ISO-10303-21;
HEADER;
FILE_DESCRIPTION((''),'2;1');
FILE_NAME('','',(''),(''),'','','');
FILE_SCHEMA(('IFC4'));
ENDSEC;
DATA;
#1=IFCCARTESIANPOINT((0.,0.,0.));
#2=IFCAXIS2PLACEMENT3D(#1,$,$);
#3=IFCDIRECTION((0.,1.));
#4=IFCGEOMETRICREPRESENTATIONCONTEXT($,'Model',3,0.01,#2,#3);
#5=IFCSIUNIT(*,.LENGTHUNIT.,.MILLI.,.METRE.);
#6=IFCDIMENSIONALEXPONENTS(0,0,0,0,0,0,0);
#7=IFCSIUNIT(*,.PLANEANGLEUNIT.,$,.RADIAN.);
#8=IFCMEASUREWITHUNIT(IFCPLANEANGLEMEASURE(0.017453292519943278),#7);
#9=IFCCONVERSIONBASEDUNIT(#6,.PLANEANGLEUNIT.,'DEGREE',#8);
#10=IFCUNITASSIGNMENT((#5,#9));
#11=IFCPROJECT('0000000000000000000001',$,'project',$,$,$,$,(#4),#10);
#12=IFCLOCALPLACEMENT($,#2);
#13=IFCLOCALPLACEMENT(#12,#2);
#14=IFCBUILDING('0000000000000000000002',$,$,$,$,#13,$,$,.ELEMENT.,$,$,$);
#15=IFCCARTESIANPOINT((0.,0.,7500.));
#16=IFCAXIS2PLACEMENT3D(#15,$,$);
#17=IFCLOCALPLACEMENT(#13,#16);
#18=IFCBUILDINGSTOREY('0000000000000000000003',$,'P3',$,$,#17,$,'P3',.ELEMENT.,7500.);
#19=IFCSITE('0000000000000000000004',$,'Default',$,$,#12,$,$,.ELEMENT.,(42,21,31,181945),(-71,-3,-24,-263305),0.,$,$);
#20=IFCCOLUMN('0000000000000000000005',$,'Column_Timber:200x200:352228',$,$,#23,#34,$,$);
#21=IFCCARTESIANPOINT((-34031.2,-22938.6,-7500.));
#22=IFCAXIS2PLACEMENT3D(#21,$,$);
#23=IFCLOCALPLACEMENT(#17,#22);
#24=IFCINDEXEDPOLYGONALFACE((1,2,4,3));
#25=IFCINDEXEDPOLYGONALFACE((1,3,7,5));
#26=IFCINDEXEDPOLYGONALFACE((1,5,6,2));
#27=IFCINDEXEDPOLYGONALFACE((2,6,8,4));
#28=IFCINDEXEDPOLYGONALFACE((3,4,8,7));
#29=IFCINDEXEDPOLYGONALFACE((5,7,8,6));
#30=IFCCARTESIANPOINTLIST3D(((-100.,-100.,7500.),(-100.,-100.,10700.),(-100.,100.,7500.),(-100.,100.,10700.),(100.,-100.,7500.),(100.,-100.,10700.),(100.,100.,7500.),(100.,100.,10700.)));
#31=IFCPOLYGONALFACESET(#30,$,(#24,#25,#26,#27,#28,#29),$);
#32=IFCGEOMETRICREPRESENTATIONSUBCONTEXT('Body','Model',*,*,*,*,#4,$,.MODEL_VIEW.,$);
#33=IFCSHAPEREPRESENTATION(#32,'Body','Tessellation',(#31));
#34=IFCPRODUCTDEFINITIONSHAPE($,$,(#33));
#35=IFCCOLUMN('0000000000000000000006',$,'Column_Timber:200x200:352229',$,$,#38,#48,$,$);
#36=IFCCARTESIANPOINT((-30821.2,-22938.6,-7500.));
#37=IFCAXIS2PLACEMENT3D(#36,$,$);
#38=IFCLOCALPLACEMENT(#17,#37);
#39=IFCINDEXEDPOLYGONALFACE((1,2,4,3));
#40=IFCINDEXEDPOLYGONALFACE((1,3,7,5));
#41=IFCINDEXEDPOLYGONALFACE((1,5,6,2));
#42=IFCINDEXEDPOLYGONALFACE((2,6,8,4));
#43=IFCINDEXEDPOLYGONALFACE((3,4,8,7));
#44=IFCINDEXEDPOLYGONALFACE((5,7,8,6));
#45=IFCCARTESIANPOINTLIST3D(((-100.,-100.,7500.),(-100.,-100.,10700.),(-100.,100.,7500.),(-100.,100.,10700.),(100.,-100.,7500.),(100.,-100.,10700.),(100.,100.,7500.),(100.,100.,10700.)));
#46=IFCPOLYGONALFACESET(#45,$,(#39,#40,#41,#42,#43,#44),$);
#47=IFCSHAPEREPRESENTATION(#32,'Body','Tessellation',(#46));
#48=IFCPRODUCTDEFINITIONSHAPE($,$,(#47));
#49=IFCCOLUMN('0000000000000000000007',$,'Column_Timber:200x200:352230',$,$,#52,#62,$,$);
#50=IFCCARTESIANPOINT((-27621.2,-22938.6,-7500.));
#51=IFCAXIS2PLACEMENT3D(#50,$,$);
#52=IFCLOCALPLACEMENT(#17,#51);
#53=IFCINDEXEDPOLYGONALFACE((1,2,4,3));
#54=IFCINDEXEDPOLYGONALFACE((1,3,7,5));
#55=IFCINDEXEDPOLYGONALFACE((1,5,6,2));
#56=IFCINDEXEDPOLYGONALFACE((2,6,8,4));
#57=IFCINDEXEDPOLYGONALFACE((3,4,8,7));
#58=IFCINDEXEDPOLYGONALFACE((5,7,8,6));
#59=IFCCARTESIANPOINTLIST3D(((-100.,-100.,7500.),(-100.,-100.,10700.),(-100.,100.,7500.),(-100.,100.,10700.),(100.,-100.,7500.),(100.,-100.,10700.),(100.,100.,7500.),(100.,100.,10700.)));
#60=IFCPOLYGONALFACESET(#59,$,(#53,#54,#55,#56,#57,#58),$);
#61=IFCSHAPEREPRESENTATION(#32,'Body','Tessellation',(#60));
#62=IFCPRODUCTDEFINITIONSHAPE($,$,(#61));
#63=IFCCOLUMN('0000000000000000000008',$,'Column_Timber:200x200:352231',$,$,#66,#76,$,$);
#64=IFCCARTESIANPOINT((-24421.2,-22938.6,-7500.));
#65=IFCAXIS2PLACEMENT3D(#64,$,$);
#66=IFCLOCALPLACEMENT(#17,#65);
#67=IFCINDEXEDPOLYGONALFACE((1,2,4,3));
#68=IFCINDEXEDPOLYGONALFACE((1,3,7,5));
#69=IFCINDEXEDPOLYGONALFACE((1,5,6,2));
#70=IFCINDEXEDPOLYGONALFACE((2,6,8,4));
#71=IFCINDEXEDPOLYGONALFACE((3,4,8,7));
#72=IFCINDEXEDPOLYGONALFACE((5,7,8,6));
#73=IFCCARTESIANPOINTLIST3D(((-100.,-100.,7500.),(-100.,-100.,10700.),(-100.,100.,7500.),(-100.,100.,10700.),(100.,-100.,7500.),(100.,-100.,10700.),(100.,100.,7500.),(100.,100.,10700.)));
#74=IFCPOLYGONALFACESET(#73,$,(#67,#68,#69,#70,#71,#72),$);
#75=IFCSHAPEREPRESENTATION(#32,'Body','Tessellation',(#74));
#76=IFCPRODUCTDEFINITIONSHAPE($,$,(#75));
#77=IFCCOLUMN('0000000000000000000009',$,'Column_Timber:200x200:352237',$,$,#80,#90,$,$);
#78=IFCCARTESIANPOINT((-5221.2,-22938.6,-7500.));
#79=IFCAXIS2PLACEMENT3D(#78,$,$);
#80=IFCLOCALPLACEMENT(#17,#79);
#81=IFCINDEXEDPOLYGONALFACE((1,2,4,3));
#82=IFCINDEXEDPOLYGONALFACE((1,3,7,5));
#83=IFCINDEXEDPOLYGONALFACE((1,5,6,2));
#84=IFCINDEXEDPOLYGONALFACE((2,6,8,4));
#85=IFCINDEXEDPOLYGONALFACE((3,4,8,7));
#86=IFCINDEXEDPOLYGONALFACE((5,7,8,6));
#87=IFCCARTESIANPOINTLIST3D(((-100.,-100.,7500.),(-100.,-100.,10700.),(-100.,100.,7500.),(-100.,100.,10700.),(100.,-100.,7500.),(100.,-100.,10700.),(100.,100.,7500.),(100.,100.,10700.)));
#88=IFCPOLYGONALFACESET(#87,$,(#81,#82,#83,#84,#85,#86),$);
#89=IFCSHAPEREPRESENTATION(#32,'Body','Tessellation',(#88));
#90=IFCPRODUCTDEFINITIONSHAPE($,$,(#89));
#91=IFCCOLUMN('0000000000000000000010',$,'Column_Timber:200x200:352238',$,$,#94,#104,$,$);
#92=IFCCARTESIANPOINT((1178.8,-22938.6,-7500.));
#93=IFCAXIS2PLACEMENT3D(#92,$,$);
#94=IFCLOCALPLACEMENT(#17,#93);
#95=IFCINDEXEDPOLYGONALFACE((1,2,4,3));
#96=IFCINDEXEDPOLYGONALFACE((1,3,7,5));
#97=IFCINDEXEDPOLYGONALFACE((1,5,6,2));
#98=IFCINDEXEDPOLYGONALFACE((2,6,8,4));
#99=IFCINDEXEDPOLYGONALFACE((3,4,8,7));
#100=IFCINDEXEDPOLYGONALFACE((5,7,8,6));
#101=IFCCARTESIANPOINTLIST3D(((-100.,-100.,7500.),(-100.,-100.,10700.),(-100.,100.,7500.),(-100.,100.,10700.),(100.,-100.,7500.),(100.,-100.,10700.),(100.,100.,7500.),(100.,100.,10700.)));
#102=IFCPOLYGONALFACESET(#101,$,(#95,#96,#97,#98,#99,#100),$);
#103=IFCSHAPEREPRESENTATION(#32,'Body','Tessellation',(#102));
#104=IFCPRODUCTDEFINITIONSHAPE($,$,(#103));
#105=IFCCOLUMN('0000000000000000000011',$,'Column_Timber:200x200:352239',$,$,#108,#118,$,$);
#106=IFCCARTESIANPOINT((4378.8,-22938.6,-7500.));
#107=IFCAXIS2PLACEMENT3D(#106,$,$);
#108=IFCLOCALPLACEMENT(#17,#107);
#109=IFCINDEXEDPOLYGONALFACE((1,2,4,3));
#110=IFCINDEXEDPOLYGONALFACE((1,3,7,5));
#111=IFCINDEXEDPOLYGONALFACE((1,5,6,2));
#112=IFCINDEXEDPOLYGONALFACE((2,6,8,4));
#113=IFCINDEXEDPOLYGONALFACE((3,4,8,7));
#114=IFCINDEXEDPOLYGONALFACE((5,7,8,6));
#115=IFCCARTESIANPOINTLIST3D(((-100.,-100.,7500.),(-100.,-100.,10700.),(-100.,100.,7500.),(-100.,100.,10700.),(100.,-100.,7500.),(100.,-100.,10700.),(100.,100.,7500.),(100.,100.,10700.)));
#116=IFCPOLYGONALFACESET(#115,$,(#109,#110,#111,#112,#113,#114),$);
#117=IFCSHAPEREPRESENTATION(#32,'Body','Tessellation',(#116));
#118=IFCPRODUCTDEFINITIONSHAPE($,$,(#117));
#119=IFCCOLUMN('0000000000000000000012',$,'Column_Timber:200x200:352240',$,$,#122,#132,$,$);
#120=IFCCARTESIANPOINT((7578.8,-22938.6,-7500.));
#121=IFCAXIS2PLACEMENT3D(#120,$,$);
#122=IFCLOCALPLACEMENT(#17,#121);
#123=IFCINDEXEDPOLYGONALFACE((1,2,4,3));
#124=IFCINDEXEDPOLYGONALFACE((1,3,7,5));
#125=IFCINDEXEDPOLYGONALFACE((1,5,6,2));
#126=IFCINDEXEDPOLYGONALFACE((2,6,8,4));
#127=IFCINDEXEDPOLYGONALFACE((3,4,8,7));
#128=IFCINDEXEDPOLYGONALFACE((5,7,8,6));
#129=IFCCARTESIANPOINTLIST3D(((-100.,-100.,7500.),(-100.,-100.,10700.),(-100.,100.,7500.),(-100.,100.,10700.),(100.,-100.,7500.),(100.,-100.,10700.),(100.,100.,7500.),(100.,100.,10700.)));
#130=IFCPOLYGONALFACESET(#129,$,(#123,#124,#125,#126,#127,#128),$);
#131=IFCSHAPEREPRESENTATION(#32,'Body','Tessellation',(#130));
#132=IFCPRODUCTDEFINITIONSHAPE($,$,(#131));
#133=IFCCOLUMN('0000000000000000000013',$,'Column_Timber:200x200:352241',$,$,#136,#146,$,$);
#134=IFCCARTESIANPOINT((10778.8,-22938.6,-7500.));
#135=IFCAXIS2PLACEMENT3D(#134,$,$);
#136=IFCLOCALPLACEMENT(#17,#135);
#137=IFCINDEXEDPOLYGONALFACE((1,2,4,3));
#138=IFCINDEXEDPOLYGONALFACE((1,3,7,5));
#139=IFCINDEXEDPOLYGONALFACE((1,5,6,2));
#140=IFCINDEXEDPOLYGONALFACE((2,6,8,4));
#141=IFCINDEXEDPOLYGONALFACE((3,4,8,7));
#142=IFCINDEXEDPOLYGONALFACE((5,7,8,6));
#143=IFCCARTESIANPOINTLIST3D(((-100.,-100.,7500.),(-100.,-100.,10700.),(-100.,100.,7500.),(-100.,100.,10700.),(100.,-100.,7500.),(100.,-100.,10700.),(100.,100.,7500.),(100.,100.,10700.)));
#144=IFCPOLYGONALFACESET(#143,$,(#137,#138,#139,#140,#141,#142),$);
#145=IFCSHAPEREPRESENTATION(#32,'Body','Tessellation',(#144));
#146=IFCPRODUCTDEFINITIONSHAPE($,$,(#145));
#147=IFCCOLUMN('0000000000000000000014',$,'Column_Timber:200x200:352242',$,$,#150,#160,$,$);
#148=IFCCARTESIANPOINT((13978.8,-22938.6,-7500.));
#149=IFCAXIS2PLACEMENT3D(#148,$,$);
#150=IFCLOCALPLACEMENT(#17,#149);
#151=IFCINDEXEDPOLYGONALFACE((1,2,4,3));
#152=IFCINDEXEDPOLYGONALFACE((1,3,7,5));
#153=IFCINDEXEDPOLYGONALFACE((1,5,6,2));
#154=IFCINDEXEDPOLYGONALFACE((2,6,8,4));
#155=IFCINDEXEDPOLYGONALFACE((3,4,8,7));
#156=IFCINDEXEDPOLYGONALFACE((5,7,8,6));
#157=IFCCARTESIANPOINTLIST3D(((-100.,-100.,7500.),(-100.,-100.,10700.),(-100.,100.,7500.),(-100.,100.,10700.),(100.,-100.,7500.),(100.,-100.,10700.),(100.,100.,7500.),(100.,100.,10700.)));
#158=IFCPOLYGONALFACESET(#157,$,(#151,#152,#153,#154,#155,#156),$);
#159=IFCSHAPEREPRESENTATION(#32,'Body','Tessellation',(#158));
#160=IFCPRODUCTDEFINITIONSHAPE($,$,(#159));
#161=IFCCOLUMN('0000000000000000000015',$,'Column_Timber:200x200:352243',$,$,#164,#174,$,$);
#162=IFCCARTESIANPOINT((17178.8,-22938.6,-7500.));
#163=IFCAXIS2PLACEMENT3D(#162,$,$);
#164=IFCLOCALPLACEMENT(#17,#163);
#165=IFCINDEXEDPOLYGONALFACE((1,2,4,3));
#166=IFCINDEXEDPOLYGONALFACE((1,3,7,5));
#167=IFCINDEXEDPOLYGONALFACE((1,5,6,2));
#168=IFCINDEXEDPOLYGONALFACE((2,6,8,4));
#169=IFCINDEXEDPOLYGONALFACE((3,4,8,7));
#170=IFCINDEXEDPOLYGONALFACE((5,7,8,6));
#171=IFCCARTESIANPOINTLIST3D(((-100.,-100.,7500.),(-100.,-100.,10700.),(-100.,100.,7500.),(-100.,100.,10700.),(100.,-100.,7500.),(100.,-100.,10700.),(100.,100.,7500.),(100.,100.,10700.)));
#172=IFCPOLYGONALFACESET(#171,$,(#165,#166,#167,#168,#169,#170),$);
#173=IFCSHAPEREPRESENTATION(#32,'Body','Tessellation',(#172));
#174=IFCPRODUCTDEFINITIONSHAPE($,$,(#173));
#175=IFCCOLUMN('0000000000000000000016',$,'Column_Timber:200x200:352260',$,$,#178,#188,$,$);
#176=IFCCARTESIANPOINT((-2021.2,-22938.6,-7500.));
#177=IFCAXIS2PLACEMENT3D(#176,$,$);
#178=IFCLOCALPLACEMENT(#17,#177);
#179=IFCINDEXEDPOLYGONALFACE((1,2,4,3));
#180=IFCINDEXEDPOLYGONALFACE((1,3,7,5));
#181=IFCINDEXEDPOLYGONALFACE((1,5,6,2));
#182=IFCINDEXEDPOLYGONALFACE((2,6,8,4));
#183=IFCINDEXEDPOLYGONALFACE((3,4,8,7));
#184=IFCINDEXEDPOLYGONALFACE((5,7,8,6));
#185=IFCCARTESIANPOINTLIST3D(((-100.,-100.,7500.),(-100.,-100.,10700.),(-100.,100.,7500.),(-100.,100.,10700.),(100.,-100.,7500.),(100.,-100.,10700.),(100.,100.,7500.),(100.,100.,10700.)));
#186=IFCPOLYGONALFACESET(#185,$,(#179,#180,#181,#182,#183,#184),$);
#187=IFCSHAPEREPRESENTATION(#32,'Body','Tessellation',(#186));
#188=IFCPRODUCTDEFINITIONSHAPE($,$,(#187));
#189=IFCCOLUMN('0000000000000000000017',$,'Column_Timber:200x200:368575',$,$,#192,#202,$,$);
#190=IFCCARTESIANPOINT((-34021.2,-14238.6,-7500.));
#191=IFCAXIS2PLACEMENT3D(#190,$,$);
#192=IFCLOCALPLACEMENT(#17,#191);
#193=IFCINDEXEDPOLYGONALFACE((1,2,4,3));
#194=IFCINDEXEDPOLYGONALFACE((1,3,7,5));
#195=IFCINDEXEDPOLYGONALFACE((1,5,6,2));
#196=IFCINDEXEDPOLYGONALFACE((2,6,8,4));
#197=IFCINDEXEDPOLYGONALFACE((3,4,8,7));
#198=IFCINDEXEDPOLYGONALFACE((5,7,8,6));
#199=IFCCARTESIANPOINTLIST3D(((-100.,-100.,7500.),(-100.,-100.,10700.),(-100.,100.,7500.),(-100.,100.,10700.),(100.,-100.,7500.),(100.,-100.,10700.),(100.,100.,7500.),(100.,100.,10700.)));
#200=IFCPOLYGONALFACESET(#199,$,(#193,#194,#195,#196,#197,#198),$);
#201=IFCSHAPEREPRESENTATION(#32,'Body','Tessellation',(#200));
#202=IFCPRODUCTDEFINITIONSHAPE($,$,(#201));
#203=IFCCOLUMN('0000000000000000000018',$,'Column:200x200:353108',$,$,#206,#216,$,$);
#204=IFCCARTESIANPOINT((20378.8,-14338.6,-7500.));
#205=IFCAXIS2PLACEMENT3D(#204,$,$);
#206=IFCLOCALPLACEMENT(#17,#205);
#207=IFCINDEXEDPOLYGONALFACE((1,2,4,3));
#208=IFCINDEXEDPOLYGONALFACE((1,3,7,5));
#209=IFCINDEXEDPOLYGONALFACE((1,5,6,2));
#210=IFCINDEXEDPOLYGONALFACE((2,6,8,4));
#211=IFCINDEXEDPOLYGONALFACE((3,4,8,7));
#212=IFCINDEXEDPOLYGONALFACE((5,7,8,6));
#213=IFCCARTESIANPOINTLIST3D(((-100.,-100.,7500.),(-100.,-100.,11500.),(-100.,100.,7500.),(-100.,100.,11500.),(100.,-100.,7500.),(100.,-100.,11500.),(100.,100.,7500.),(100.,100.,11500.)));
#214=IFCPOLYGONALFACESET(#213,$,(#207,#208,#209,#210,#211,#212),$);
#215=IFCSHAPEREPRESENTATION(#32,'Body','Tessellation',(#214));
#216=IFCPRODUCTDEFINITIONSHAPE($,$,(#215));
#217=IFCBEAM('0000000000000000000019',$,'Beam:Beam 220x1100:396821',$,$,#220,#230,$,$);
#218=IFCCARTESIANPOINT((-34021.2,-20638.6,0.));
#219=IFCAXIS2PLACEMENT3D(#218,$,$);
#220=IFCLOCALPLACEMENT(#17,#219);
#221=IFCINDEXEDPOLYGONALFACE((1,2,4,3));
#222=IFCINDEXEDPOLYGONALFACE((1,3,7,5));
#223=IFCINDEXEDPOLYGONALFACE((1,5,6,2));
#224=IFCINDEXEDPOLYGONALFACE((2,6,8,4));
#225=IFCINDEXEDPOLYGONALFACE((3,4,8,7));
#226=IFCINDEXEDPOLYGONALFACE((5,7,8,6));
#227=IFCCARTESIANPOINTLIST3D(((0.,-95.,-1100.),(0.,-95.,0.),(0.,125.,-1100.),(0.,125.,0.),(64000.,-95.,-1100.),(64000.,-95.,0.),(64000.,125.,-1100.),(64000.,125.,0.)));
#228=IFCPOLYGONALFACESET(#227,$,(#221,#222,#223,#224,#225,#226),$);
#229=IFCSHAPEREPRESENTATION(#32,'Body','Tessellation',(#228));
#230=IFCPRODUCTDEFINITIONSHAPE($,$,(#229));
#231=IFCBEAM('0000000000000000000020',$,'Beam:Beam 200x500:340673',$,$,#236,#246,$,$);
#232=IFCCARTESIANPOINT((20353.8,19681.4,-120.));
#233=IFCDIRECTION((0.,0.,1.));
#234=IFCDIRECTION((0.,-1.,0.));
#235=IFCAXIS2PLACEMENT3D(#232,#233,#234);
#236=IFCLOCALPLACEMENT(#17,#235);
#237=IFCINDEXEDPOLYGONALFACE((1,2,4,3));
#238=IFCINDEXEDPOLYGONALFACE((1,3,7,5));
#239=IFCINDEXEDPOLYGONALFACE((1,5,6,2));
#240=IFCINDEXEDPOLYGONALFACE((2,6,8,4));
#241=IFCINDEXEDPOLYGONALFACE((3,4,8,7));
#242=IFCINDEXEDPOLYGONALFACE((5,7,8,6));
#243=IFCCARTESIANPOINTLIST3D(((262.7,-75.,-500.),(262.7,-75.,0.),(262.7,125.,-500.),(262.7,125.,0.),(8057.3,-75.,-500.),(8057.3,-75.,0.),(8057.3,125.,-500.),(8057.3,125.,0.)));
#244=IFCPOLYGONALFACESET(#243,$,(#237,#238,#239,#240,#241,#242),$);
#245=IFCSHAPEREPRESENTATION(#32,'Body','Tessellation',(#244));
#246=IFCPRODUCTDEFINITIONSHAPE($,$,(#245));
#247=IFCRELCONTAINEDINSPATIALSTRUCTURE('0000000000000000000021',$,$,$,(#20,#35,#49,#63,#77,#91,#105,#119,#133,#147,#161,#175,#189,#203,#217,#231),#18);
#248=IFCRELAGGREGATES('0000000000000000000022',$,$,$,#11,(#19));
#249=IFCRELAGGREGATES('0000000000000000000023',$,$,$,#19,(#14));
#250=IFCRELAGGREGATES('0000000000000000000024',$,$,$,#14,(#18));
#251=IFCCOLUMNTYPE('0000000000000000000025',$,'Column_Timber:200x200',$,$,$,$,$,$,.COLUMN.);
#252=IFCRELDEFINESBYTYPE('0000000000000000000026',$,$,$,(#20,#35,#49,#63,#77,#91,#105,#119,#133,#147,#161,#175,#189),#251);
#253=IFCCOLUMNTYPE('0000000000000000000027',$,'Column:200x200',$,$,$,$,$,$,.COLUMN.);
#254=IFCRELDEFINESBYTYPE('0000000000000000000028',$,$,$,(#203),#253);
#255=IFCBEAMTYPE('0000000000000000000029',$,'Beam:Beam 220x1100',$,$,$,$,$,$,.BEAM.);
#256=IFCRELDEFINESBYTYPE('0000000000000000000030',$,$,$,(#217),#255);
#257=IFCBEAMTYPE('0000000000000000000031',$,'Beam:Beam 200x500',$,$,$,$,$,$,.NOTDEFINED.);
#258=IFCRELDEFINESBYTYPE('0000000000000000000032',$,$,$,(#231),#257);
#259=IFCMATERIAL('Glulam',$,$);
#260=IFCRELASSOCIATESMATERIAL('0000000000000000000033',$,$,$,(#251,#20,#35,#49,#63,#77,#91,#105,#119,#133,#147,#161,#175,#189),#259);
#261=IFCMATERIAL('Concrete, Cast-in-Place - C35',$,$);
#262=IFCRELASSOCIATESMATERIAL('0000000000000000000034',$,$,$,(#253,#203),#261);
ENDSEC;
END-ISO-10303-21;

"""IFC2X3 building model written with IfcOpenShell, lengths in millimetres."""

from ifc_helpers import new_model, entity, si_unit, converted_unit, direction, frame, frame_2d, origin, place, context, subcontext, project, spatial, rectangle, extrude, source, transform, mapped, material, type_object, type_shapes, element, save


model = new_model("IFC2X3")

# Units and contexts
model_context = context("Model", 3, precision=0.01, world=origin(), true_north=direction((0.0, 1.0)))
body_context = subcontext(model_context, "Body", "Model", "MODEL_VIEW")
ifc_project = project(units=[si_unit("LENGTHUNIT", "METRE", prefix="MILLI"), converted_unit("PLANEANGLEUNIT", "DEGREE", entity("IfcPlaneAngleMeasure", 0.017453292519943278), si_unit("PLANEANGLEUNIT", "RADIAN"), dimensions=[0, 0, 0, 0, 0, 0, 0])], contexts=[model_context])

# Site, building, storey
site_placement = place(None, origin())
site = spatial("IfcSite", under=ifc_project, at=site_placement, Name="Default", CompositionType="ELEMENT", RefLatitude=(42, 21, 31, 181945), RefLongitude=(-71, -3, -24, -263305), RefElevation=0.0)
building_placement = place(site_placement, origin())
building = spatial("IfcBuilding", under=site, at=building_placement, CompositionType="ELEMENT")
storey_placement = place(building_placement, frame((0.0, 0.0, 7500.0)))
storey = spatial("IfcBuildingStorey", under=building, at=storey_placement, Name="P3", LongName="P3", CompositionType="ELEMENT", Elevation=7500.0)

# Columns
ifc_material_1 = material(Name="Glulam")
column_type_1 = type_object("IfcColumnType", Name="Column_Timber:200x200", PredefinedType="COLUMN", material=ifc_material_1)
shared_shape_1 = source(origin(), body_context, "Body", "SweptSolid", [
    extrude(rectangle(XDim=200.0, YDim=200.0, at=frame_2d((0.0, 0.0), x_axis=(1.0, 0.0))), frame((0.0, 0.0, 7500.0), z_axis=(0.0, 0.0, 1.0), x_axis=(-1.0, 0.0, 0.0)), (0.0, 0.0, 1.0), 3200.0),
])
type_shapes(column_type_1, [shared_shape_1])
for number, where, name in (
    (1, (-34031.2, -22938.6, -7500.0), "Column_Timber:200x200:352228"),
    (2, (-30821.2, -22938.6, -7500.0), "Column_Timber:200x200:352229"),
    (3, (-27621.2, -22938.6, -7500.0), "Column_Timber:200x200:352230"),
    (4, (-24421.2, -22938.6, -7500.0), "Column_Timber:200x200:352231"),
    (5, (-5221.2, -22938.6, -7500.0), "Column_Timber:200x200:352237"),
    (6, (1178.8, -22938.6, -7500.0), "Column_Timber:200x200:352238"),
    (7, (4378.8, -22938.6, -7500.0), "Column_Timber:200x200:352239"),
    (8, (7578.8, -22938.6, -7500.0), "Column_Timber:200x200:352240"),
    (9, (10778.8, -22938.6, -7500.0), "Column_Timber:200x200:352241"),
    (10, (13978.8, -22938.6, -7500.0), "Column_Timber:200x200:352242"),
    (11, (17178.8, -22938.6, -7500.0), "Column_Timber:200x200:352243"),
    (12, (-2021.2, -22938.6, -7500.0), "Column_Timber:200x200:352260"),
    (13, (-34021.2, -14238.6, -7500.0), "Column_Timber:200x200:368575"),
):
    element("IfcColumn", number, at=place(storey_placement, frame(where)), inside=storey, type_object=column_type_1, material=ifc_material_1, Name=name, context=body_context, shape_type="MappedRepresentation", body=[
        mapped(shared_shape_1, transform((0.0, 0.0, 0.0), scale=1.0)),
    ])
ifc_material_2 = material(Name="Concrete, Cast-in-Place - C35")
column_type_2 = type_object("IfcColumnType", Name="Column:200x200", PredefinedType="COLUMN", material=ifc_material_2)
shared_shape_2 = source(origin(), body_context, "Body", "SweptSolid", [
    extrude(rectangle(XDim=200.0, YDim=200.0, at=frame_2d((0.0, 0.0), x_axis=(1.0, 0.0))), frame((0.0, 0.0, 7500.0), z_axis=(0.0, 0.0, 1.0), x_axis=(-1.0, 0.0, 0.0)), (0.0, 0.0, 1.0), 4000.0),
])
type_shapes(column_type_2, [shared_shape_2])
column_placement = place(storey_placement, frame((20378.8, -14338.6, -7500.0)))
element("IfcColumn", 14, at=column_placement, inside=storey, type_object=column_type_2, material=ifc_material_2, Name="Column:200x200:353108", context=body_context, shape_type="MappedRepresentation", body=[
    mapped(shared_shape_2, transform((0.0, 0.0, 0.0), scale=1.0)),
])

# Beams
beam_type_1 = type_object("IfcBeamType", Name="Beam:Beam 220x1100", PredefinedType="BEAM")
beam_1_placement = place(storey_placement, frame((-34021.2, -20638.6, 0.0)))
element("IfcBeam", 15, at=beam_1_placement, inside=storey, type_object=beam_type_1, Name="Beam:Beam 220x1100:396821", context=body_context, shape_type="SweptSolid", body=[
    extrude(rectangle(XDim=1100.0, YDim=220.0, at=frame_2d((0.0, 0.0), x_axis=(1.0, 0.0))), frame((0.0, 15.0, -550.0), z_axis=(1.0, 0.0, 0.0), x_axis=(0.0, 0.0, -1.0)), (0.0, 0.0, 1.0), 64000.0),
])
beam_type_2 = type_object("IfcBeamType", Name="Beam:Beam 200x500", PredefinedType="NOTDEFINED")
beam_2_placement = place(storey_placement, frame((20353.8, 19681.4, -120.0), z_axis=(0.0, 0.0, 1.0), x_axis=(0.0, -1.0, 0.0)))
element("IfcBeam", 16, at=beam_2_placement, inside=storey, type_object=beam_type_2, Name="Beam:Beam 200x500:340673", context=body_context, shape_type="SweptSolid", body=[
    extrude(rectangle(XDim=500.0, YDim=200.0, at=frame_2d((0.0, 0.0), x_axis=(1.0, 0.0))), frame((262.7, 25.0, -250.0), z_axis=(1.0, 0.0, 0.0), x_axis=(0.0, 0.0, -1.0)), (0.0, 0.0, 1.0), 7794.6),
])

save(model, "model.ifc")
